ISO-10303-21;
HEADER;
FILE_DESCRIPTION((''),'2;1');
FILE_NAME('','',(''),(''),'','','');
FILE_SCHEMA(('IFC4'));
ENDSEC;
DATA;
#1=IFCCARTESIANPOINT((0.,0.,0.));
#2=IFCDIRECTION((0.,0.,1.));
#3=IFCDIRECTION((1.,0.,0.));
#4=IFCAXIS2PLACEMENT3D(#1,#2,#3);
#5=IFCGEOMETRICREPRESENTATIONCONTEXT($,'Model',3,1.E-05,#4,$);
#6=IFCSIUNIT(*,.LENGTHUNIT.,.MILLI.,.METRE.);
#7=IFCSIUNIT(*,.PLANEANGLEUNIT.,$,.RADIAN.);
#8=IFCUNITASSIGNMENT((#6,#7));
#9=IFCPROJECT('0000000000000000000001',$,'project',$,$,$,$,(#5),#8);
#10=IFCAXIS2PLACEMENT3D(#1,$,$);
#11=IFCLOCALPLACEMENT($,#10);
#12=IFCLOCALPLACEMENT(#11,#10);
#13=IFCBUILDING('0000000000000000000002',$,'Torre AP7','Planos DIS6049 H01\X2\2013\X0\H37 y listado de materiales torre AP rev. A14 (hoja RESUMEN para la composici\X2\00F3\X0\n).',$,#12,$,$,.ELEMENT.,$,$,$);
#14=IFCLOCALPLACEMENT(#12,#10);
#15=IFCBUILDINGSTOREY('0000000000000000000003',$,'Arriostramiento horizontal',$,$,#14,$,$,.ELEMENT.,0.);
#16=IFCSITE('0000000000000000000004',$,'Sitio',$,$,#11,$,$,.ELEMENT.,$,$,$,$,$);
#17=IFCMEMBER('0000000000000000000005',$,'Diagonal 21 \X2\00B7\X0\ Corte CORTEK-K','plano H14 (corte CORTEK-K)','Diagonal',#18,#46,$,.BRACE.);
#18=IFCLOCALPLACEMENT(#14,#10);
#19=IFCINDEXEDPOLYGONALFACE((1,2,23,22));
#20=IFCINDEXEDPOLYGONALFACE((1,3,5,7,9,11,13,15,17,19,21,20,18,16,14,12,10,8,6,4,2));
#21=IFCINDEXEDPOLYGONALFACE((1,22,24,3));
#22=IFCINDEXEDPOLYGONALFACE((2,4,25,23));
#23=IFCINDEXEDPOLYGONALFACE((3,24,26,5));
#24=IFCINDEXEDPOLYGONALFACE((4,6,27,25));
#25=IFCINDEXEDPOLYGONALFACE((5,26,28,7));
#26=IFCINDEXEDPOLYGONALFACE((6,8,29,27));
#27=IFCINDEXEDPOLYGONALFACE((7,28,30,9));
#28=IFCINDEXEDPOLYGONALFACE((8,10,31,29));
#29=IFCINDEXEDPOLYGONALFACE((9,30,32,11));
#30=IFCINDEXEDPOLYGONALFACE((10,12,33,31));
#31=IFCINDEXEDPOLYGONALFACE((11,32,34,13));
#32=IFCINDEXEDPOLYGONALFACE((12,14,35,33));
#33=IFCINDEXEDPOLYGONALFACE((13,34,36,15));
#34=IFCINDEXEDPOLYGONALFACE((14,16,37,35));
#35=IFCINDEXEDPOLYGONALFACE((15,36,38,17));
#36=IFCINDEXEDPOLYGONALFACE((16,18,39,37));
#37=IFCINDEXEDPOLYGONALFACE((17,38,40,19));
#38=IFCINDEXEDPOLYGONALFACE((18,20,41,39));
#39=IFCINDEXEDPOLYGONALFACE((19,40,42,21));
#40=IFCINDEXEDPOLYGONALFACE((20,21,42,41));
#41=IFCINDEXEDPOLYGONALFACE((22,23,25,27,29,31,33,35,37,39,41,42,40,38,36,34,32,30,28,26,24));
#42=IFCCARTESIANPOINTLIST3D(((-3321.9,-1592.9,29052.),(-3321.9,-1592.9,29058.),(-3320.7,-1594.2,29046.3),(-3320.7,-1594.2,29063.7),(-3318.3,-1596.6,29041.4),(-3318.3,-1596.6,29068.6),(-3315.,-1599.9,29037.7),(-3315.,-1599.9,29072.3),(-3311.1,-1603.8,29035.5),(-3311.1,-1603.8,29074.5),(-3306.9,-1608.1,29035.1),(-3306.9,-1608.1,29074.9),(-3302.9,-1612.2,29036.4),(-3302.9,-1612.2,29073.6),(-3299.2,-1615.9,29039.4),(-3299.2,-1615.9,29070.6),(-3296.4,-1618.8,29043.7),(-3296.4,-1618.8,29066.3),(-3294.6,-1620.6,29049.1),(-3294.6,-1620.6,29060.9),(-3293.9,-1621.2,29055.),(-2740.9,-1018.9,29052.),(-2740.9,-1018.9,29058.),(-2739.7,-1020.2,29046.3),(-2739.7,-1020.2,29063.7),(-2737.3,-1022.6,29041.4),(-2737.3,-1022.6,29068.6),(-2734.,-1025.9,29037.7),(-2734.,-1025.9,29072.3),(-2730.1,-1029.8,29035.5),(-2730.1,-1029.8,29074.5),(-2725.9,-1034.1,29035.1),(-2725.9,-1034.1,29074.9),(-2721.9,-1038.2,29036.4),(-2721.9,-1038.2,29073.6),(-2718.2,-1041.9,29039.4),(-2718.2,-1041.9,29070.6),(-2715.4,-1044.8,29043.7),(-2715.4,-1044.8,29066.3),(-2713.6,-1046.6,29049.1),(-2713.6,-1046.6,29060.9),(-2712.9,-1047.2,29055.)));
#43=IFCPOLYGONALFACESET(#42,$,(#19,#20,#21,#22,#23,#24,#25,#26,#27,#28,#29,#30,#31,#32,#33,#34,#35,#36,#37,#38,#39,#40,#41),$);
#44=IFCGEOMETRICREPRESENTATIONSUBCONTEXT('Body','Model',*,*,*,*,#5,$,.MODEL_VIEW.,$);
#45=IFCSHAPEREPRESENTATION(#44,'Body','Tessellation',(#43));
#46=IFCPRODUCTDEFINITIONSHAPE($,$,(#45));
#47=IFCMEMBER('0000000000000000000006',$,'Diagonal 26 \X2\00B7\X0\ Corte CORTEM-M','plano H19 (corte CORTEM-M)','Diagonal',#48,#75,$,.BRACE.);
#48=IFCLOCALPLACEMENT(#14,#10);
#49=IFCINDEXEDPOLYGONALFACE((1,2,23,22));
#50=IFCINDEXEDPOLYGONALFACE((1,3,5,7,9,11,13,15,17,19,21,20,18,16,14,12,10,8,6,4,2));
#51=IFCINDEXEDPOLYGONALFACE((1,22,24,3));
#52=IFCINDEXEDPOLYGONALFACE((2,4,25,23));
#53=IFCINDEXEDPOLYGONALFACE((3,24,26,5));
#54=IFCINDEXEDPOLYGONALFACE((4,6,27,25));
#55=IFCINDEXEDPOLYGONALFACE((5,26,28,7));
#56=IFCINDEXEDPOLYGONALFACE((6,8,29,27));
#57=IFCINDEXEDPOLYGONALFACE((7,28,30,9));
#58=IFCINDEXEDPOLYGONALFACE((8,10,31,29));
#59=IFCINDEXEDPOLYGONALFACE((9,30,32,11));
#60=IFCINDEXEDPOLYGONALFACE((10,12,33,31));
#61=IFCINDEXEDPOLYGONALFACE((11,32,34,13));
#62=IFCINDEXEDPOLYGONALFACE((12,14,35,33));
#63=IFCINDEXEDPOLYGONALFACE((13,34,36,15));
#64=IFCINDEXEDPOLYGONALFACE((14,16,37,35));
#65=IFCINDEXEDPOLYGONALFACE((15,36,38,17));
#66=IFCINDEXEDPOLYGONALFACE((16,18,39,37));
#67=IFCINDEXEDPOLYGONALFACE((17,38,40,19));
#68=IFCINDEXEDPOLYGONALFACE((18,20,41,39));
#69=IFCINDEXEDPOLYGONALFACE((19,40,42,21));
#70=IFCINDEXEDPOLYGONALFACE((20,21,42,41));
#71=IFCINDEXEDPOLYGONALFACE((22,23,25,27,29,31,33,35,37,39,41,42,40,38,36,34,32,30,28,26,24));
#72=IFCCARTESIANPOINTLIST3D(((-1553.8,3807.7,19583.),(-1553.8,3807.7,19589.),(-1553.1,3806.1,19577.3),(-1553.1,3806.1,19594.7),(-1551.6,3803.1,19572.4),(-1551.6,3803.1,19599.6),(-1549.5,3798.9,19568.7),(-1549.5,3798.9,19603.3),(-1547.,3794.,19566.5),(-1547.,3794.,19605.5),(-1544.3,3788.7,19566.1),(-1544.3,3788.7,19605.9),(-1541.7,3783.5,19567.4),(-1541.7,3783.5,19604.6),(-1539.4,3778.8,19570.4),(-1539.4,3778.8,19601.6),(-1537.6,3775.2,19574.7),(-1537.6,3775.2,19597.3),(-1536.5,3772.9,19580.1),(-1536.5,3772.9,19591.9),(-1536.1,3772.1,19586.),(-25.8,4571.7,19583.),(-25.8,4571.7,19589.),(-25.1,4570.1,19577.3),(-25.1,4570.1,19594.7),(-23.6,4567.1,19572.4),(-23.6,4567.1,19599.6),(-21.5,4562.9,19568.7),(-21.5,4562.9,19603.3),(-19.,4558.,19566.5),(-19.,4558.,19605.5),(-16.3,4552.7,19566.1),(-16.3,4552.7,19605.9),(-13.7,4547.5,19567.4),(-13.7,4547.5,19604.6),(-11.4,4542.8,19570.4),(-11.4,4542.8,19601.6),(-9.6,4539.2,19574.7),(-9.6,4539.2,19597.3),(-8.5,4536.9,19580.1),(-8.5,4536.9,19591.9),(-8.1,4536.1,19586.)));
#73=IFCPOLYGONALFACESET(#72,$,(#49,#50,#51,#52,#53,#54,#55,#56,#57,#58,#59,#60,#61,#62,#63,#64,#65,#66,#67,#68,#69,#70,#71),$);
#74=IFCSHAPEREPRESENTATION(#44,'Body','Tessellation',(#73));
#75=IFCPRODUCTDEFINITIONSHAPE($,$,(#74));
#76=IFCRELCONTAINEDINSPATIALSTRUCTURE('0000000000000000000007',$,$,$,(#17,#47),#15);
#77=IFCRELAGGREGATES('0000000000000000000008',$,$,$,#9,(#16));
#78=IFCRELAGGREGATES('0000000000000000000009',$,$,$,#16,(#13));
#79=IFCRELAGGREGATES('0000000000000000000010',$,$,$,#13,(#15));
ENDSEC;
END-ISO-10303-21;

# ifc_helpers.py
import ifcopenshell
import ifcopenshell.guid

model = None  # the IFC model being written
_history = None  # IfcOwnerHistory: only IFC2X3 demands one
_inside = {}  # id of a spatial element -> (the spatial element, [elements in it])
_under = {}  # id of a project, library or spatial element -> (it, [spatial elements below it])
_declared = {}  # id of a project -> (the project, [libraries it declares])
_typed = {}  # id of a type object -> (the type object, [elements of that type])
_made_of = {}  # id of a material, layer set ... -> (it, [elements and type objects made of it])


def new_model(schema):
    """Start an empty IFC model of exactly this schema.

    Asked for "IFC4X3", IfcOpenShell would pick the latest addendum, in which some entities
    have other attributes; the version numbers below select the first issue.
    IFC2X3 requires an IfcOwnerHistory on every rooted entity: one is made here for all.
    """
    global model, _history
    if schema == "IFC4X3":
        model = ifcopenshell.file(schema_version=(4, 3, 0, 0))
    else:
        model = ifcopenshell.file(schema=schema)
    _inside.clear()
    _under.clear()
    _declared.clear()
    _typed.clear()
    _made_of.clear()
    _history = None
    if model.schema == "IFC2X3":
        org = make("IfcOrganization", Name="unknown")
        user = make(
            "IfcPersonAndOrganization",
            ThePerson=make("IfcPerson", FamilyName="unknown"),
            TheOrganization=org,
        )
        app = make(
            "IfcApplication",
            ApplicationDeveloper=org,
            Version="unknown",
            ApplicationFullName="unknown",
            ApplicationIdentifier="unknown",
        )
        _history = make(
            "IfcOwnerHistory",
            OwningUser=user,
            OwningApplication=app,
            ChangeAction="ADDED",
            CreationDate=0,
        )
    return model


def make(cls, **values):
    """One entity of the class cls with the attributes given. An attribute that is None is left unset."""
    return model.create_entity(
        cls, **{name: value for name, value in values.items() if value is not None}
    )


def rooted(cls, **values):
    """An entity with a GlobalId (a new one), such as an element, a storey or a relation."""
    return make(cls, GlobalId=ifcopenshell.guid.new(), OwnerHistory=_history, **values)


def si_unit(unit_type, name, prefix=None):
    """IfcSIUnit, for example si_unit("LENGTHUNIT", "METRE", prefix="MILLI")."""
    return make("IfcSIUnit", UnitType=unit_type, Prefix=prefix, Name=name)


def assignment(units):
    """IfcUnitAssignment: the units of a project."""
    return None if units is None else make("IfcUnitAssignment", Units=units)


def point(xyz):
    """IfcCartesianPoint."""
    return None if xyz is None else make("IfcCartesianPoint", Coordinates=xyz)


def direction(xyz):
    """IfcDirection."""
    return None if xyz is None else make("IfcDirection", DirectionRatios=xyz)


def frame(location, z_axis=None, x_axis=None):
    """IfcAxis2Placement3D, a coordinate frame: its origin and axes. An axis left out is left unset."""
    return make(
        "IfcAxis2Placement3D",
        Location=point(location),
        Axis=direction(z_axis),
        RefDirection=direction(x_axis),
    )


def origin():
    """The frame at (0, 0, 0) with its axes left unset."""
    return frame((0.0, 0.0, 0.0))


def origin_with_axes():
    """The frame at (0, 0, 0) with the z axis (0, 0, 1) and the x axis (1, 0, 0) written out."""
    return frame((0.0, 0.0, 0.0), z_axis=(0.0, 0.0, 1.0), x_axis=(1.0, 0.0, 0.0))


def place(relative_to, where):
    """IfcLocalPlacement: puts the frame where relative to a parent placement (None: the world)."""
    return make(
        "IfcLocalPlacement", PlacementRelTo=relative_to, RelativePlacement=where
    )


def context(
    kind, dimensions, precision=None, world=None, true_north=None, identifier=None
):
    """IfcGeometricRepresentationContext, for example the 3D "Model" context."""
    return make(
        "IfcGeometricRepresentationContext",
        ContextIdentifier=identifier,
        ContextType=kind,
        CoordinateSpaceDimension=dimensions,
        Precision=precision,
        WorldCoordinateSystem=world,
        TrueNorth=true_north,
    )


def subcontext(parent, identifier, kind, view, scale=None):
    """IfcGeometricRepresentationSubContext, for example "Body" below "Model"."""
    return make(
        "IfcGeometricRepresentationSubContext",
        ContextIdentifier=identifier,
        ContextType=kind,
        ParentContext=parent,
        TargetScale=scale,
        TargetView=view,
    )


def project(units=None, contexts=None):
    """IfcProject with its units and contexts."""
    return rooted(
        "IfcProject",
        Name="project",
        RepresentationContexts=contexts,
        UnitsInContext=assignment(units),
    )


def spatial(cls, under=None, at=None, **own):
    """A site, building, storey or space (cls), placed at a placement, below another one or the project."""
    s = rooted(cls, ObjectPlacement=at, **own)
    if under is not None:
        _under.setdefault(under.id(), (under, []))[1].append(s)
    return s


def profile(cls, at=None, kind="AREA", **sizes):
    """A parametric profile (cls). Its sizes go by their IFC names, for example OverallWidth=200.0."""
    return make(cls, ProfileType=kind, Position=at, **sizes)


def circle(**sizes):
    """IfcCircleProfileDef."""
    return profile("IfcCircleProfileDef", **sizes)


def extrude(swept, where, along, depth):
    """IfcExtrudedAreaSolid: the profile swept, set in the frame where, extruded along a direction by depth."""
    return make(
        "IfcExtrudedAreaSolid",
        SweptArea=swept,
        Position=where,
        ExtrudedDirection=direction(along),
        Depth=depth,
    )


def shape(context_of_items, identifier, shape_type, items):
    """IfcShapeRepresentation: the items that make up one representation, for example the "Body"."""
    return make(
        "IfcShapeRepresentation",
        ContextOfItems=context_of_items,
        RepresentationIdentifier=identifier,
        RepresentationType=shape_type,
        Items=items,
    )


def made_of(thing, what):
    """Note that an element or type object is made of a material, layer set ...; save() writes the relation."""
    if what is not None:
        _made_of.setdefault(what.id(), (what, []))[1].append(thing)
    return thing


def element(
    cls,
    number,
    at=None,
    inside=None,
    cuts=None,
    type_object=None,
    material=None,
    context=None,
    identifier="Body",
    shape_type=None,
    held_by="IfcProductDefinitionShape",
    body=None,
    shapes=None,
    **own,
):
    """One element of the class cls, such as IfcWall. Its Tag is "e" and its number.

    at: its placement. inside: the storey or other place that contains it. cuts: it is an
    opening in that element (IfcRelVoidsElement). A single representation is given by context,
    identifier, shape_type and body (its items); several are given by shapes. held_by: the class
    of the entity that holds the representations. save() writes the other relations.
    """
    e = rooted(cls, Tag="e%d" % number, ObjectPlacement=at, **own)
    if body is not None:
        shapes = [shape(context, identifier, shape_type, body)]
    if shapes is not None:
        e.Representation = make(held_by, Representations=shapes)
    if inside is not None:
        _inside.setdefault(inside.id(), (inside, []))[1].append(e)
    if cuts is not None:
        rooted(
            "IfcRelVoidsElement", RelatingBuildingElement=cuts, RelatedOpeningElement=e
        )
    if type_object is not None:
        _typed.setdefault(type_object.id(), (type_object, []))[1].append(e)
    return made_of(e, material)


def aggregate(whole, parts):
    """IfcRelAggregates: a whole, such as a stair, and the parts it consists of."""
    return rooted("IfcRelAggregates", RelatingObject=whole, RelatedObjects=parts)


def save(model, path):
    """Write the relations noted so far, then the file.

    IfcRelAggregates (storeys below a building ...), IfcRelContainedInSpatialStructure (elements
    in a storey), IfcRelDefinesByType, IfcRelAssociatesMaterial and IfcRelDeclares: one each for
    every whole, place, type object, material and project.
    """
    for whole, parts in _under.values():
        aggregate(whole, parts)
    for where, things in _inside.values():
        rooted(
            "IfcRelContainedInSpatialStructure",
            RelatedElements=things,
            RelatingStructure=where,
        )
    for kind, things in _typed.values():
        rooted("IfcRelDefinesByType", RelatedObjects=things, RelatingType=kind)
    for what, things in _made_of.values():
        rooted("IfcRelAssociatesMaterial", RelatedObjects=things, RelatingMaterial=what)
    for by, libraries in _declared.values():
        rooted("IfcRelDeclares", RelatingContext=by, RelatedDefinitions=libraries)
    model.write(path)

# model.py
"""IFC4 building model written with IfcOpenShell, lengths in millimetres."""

from ifc_helpers import new_model, si_unit, frame, origin, origin_with_axes, place, context, subcontext, project, spatial, circle, extrude, element, save


model = new_model("IFC4")

# Units and contexts
model_context = context("Model", 3, precision=1e-05, world=origin_with_axes())
body_context = subcontext(model_context, "Body", "Model", "MODEL_VIEW")
ifc_project = project(units=[si_unit("LENGTHUNIT", "METRE", prefix="MILLI"), si_unit("PLANEANGLEUNIT", "RADIAN")], contexts=[model_context])

# Site, building, storey
site_placement = place(None, origin())
site = spatial("IfcSite", under=ifc_project, at=site_placement, Name="Sitio", CompositionType="ELEMENT")
building_placement = place(site_placement, origin())
building = spatial("IfcBuilding", under=site, at=building_placement, Name="Torre AP7", Description="Planos DIS6049 H01–H37 y listado de materiales torre AP rev. A14 (hoja RESUMEN para la composición).", CompositionType="ELEMENT")
storey_placement = place(building_placement, origin())
storey = spatial("IfcBuildingStorey", under=building, at=storey_placement, Name="Arriostramiento horizontal", CompositionType="ELEMENT", Elevation=0.0)

# Members
for number, where, z_axis, x_axis, name in (
    (1, (-2727.0, -1033.0, 29055.0), (-0.711379, -0.702808, 0.0), (0.702808, -0.711379, 0.0), "Diagonal 21 · Corte CORTEK-K"),
):
    element("IfcMember", number, at=place(storey_placement, frame(where, z_axis=z_axis, x_axis=x_axis)), inside=storey, Name=name, Description="plano H14 (corte CORTEK-K)", ObjectType="Diagonal", PredefinedType="BRACE", context=body_context, shape_type="SweptSolid", body=[
        extrude(circle(Radius=20.0), None, (0.0, 0.0, 1.0), 816.7),
    ])
member_1_placement = place(storey_placement, frame((-17.0, 4554.0, 19586.0), z_axis=(-0.894427, -0.447214, 0.0), x_axis=(0.447214, -0.894427, 0.0)))
element("IfcMember", 2, at=member_1_placement, inside=storey, Name="Diagonal 26 · Corte CORTEM-M", Description="plano H19 (corte CORTEM-M)", ObjectType="Diagonal", PredefinedType="BRACE", context=body_context, shape_type="SweptSolid", body=[
    extrude(circle(Radius=20.0), None, (0.0, 0.0, 1.0), 1708.4),
])

save(model, "model.ifc")
